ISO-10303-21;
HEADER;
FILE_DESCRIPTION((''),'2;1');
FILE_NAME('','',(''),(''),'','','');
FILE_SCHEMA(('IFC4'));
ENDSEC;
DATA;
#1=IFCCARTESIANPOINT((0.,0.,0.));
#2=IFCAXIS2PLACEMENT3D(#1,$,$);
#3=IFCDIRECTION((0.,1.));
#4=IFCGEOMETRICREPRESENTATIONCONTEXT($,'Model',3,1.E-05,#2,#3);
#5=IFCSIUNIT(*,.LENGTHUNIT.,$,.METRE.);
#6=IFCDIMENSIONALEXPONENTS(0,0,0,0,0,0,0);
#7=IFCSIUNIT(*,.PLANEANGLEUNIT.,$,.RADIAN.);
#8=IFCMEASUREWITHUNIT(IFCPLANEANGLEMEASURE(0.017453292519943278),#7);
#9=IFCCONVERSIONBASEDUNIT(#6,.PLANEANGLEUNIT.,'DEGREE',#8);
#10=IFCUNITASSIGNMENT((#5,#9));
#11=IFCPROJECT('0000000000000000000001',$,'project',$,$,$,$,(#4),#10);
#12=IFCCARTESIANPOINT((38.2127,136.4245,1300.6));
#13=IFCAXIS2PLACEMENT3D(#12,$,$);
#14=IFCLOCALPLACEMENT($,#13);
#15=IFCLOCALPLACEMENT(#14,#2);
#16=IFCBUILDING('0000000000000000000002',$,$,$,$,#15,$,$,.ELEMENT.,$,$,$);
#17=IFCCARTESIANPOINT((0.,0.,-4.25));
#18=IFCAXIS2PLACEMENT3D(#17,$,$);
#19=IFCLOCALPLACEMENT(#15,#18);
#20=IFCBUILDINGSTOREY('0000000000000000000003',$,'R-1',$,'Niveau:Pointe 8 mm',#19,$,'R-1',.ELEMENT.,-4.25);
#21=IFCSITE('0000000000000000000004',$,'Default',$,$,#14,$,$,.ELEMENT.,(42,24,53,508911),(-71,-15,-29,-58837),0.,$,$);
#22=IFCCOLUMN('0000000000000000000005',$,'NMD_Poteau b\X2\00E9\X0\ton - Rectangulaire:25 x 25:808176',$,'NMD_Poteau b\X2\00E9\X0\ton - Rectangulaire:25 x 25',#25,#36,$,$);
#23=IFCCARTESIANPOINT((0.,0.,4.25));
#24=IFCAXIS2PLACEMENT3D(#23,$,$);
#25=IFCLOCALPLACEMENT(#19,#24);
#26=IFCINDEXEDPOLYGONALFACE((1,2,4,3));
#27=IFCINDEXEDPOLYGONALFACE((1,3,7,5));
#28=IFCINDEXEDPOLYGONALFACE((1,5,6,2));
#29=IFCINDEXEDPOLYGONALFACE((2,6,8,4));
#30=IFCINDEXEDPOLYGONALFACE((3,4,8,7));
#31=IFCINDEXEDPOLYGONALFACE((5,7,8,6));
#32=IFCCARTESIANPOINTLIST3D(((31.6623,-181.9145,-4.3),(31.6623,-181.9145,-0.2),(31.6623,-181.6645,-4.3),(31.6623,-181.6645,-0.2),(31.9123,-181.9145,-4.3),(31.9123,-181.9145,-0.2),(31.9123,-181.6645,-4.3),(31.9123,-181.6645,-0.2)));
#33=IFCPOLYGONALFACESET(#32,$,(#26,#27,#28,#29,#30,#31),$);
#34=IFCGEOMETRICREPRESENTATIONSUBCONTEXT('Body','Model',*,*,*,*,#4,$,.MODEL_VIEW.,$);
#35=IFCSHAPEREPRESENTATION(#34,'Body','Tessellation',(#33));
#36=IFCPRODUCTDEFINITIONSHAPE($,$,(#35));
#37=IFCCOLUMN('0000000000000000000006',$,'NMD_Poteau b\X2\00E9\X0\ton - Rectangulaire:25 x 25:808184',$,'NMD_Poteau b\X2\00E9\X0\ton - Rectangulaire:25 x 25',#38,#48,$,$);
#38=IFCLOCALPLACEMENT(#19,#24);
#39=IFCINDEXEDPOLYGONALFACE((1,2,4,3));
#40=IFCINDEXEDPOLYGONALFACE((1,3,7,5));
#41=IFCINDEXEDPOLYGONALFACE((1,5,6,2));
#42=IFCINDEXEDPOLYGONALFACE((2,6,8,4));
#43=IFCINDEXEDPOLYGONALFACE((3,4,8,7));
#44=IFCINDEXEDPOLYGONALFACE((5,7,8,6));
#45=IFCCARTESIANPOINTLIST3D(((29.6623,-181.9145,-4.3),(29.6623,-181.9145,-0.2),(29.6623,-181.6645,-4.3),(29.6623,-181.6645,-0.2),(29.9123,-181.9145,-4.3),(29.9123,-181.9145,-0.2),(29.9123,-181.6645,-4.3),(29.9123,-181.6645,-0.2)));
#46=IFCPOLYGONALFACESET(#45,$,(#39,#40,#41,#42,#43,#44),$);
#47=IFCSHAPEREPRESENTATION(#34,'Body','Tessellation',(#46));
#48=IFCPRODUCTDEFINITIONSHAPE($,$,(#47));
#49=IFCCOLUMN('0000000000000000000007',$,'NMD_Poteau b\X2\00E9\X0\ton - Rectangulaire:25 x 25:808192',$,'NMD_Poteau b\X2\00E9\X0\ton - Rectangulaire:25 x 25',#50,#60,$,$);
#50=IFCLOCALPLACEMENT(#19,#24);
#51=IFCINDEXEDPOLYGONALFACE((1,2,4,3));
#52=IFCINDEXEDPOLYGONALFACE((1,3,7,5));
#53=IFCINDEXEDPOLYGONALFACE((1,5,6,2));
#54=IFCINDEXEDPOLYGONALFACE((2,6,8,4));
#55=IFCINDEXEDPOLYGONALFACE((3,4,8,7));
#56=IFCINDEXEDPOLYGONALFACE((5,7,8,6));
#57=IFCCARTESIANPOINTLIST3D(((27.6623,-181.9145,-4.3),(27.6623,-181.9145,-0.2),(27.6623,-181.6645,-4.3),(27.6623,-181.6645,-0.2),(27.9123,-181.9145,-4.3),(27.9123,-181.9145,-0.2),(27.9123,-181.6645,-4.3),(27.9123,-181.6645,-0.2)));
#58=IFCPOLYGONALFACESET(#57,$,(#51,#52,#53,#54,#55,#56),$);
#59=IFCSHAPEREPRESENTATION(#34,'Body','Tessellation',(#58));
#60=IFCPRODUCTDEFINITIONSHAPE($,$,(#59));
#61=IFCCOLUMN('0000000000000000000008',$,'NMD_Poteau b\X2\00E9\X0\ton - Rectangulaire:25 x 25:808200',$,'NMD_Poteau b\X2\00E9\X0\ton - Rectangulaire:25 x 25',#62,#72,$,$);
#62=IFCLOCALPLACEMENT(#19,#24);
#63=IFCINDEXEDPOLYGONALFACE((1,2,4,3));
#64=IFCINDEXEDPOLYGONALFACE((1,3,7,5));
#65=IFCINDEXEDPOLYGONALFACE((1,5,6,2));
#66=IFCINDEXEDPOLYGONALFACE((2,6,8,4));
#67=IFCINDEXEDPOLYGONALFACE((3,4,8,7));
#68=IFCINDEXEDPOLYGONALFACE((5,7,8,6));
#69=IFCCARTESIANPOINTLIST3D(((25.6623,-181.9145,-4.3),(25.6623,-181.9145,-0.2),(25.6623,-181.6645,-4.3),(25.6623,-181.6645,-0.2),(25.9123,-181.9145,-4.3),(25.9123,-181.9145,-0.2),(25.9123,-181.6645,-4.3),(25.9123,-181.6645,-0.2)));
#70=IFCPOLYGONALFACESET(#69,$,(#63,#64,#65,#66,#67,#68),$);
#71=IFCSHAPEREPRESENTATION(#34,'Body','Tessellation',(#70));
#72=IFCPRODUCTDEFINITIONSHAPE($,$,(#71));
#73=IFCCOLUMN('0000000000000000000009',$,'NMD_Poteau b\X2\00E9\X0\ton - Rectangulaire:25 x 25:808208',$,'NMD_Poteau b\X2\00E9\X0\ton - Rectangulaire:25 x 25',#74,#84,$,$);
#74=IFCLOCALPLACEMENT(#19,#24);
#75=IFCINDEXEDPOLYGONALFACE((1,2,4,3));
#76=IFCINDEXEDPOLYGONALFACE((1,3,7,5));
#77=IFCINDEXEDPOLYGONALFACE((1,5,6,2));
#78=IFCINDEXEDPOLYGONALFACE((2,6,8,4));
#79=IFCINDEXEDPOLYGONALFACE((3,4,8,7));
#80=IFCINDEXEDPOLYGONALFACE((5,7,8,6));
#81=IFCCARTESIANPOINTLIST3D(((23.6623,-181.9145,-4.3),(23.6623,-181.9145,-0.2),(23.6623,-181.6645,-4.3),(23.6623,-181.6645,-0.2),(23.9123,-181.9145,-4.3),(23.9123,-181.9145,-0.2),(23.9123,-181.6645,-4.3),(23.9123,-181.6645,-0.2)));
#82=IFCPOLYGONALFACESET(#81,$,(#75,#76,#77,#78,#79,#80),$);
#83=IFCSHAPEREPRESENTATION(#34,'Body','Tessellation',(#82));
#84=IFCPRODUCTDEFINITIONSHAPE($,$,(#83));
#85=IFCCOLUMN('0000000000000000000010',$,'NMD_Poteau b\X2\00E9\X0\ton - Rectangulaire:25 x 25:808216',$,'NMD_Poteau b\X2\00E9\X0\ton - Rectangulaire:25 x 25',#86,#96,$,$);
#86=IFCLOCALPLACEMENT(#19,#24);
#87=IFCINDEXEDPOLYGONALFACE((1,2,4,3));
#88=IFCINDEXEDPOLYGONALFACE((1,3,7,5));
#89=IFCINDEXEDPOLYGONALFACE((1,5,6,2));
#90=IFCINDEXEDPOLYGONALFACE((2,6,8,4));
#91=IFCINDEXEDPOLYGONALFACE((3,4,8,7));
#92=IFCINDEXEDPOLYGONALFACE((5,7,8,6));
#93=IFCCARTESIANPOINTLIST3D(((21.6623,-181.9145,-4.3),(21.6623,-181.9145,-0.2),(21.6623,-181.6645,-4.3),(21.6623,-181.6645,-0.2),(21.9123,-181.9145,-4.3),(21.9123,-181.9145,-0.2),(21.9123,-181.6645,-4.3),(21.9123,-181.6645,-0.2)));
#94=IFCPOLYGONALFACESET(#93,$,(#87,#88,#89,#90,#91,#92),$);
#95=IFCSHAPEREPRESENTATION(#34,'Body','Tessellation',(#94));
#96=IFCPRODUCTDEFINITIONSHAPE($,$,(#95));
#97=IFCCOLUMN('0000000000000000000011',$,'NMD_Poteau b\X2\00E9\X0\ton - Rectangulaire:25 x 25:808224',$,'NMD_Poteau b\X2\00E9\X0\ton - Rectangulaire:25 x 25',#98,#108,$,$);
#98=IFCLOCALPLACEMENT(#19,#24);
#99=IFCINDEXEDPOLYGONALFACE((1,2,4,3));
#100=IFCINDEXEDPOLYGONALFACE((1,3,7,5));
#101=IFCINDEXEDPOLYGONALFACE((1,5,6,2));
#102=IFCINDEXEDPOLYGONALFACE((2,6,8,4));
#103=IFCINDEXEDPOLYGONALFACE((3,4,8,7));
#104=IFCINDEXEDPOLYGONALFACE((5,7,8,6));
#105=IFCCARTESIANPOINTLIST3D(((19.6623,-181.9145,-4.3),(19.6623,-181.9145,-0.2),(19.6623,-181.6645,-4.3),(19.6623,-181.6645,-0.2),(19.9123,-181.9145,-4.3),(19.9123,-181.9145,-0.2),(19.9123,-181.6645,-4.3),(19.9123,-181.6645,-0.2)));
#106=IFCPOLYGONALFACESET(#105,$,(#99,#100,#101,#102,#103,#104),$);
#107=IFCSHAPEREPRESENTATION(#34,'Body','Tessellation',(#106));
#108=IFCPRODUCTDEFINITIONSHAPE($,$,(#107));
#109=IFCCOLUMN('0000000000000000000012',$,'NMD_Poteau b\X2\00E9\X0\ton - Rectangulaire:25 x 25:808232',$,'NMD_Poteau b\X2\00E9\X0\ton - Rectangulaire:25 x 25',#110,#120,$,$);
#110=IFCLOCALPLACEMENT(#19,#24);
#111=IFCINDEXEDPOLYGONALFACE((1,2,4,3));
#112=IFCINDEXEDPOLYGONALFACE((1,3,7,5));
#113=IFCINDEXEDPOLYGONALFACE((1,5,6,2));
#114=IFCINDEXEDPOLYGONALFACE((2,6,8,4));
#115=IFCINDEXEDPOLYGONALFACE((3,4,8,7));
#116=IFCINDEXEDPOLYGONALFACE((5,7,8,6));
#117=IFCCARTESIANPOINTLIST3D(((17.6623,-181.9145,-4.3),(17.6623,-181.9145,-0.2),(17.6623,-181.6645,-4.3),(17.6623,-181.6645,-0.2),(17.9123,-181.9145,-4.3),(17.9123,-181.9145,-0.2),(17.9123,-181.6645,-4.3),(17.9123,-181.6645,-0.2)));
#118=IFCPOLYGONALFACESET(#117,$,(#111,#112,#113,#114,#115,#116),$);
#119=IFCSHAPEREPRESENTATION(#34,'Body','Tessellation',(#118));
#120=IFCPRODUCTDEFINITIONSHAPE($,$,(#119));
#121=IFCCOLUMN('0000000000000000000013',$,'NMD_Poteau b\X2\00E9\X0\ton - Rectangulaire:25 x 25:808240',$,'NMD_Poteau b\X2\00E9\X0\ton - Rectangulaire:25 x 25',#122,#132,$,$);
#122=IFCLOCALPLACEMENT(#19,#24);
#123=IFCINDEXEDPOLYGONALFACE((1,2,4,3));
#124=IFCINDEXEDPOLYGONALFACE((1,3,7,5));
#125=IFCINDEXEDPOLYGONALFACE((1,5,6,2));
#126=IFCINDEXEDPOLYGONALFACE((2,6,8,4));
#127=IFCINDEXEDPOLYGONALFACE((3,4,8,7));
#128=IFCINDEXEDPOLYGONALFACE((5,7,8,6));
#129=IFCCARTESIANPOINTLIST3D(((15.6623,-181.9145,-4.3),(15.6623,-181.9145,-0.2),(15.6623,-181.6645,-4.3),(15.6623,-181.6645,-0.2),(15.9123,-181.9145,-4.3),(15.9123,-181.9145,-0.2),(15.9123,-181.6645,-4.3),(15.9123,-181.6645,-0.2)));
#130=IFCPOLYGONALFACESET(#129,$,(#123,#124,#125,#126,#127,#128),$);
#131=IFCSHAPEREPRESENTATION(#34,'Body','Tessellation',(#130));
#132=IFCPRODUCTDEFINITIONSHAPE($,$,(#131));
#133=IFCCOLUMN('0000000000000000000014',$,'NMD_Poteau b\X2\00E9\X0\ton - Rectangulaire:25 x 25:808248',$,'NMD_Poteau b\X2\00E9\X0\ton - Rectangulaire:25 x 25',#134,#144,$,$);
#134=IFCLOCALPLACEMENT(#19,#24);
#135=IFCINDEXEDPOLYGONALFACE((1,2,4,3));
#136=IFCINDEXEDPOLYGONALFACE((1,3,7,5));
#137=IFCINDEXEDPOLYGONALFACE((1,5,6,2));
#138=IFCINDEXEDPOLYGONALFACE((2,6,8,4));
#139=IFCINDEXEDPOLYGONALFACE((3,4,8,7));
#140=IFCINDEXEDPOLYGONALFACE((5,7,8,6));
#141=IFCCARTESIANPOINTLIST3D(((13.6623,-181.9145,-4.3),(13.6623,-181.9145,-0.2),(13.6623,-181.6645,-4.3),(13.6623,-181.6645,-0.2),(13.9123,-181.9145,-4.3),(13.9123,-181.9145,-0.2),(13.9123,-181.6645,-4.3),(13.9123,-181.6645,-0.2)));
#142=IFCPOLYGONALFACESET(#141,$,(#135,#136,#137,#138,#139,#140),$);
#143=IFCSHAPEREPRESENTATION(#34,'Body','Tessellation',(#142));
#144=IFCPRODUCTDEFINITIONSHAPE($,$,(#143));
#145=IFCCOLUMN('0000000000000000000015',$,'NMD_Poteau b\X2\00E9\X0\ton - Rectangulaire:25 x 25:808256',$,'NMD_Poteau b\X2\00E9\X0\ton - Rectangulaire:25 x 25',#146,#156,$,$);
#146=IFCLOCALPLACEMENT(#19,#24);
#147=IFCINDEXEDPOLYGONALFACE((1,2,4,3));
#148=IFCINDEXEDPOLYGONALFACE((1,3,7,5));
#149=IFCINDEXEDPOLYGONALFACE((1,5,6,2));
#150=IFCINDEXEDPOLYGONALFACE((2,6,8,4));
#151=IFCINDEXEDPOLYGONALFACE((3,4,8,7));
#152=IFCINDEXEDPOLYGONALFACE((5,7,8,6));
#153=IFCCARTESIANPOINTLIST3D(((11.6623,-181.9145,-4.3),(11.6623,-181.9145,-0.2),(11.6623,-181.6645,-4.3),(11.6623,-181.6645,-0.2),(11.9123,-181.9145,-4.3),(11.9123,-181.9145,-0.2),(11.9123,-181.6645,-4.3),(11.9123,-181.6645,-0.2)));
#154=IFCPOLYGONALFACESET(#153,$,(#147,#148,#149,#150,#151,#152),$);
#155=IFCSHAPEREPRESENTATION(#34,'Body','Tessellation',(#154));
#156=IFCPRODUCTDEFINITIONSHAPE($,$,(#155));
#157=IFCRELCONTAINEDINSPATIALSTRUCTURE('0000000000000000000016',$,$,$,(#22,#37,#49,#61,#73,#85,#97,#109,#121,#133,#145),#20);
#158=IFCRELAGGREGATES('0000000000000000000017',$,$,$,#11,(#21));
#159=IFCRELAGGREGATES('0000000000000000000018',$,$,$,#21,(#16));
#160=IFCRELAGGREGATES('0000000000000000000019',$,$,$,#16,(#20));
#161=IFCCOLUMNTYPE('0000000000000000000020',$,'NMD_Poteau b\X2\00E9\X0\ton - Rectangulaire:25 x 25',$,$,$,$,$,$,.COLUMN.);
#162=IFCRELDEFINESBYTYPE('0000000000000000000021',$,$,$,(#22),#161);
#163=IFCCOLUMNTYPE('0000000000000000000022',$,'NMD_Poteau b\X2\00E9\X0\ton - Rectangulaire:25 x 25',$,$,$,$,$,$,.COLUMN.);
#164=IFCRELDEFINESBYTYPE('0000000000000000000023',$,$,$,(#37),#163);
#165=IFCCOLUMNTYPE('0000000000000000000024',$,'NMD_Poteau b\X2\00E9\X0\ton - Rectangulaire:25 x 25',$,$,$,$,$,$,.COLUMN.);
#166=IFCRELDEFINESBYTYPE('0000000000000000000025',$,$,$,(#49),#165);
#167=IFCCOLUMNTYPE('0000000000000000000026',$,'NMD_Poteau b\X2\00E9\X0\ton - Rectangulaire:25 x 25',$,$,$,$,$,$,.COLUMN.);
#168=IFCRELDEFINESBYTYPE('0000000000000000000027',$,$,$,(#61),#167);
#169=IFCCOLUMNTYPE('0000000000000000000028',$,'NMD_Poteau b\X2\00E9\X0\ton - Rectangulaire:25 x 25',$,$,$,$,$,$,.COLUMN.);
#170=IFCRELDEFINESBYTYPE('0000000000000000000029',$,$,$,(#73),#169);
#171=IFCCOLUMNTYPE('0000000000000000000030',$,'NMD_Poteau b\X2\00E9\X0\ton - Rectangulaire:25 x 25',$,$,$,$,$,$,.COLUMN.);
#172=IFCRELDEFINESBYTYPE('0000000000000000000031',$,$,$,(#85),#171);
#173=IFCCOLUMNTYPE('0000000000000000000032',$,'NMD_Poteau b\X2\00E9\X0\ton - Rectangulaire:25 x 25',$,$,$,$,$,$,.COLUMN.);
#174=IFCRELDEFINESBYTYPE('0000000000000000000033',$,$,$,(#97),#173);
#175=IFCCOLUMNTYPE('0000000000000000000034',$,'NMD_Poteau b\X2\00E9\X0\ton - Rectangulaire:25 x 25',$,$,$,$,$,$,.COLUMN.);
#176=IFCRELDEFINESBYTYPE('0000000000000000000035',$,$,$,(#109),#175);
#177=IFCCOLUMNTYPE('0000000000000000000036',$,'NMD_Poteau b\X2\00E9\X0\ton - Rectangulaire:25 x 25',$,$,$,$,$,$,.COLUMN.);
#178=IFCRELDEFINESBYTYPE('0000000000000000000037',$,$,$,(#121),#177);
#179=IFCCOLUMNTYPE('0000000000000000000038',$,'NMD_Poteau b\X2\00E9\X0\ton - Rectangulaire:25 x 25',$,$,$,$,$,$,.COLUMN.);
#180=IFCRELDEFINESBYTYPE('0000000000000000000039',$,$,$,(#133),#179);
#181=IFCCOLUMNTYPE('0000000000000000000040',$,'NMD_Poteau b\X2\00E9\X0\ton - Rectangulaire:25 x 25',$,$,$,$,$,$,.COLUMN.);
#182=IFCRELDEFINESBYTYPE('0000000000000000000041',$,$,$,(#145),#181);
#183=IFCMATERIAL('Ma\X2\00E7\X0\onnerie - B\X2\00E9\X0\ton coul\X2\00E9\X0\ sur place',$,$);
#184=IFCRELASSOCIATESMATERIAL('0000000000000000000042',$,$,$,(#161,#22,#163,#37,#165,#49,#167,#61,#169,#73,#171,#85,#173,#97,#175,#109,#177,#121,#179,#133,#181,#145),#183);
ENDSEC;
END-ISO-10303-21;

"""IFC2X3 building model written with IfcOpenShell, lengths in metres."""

from ifc_helpers import new_model, entity, si_unit, converted_unit, direction, frame, frame_2d, origin, place, context, subcontext, project, spatial, rectangle, extrude, source, transform, mapped, material, type_object, type_shapes, element, save


model = new_model("IFC2X3")

# Units and contexts
model_context = context("Model", 3, precision=1e-05, world=origin(), true_north=direction((0.0, 1.0)))
body_context = subcontext(model_context, "Body", "Model", "MODEL_VIEW")
ifc_project = project(units=[si_unit("LENGTHUNIT", "METRE"), converted_unit("PLANEANGLEUNIT", "DEGREE", entity("IfcPlaneAngleMeasure", 0.017453292519943278), si_unit("PLANEANGLEUNIT", "RADIAN"), dimensions=[0, 0, 0, 0, 0, 0, 0])], contexts=[model_context])

# Site, building, storey
site_placement = place(None, frame((38.2127, 136.4245, 1300.6)))
site = spatial("IfcSite", under=ifc_project, at=site_placement, Name="Default", CompositionType="ELEMENT", RefLatitude=(42, 24, 53, 508911), RefLongitude=(-71, -15, -29, -58837), RefElevation=0.0)
building_placement = place(site_placement, origin())
building = spatial("IfcBuilding", under=site, at=building_placement, CompositionType="ELEMENT")
storey_placement = place(building_placement, frame((0.0, 0.0, -4.25)))
storey = spatial("IfcBuildingStorey", under=building, at=storey_placement, Name="R-1", ObjectType="Niveau:Pointe 8 mm", LongName="R-1", CompositionType="ELEMENT", Elevation=-4.25)

# Columns
ifc_material = material(Name="Maçonnerie - Béton coulé sur place")
column_type_1 = type_object("IfcColumnType", Name="NMD_Poteau béton - Rectangulaire:25 x 25", PredefinedType="COLUMN", material=ifc_material)
shared_shape_1 = source(origin(), body_context, "Body", "SweptSolid", [
    extrude(rectangle(XDim=0.25, YDim=0.25, at=frame_2d((0.0, 0.0), x_axis=(1.0, 0.0))), frame((31.7873, -181.7895, -4.3), z_axis=(0.0, 0.0, 1.0), x_axis=(-1.0, 0.0, 0.0)), (0.0, 0.0, 1.0), 4.1),
])
type_shapes(column_type_1, [shared_shape_1])
column_1_placement = place(storey_placement, frame((0.0, 0.0, 4.25)))
element("IfcColumn", 1, at=column_1_placement, inside=storey, type_object=column_type_1, material=ifc_material, Name="NMD_Poteau béton - Rectangulaire:25 x 25:808176", ObjectType="NMD_Poteau béton - Rectangulaire:25 x 25", context=body_context, shape_type="MappedRepresentation", body=[
    mapped(shared_shape_1, transform((0.0, 0.0, 0.0), scale=1.0)),
])
column_type_2 = type_object("IfcColumnType", Name="NMD_Poteau béton - Rectangulaire:25 x 25", PredefinedType="COLUMN", material=ifc_material)
shared_shape_2 = source(origin(), body_context, "Body", "SweptSolid", [
    extrude(rectangle(XDim=0.25, YDim=0.25, at=frame_2d((0.0, 0.0), x_axis=(1.0, 0.0))), frame((29.7873, -181.7895, -4.3), z_axis=(0.0, 0.0, 1.0), x_axis=(-1.0, 0.0, 0.0)), (0.0, 0.0, 1.0), 4.1),
])
type_shapes(column_type_2, [shared_shape_2])
column_2_placement = place(storey_placement, frame((0.0, 0.0, 4.25)))
element("IfcColumn", 2, at=column_2_placement, inside=storey, type_object=column_type_2, material=ifc_material, Name="NMD_Poteau béton - Rectangulaire:25 x 25:808184", ObjectType="NMD_Poteau béton - Rectangulaire:25 x 25", context=body_context, shape_type="MappedRepresentation", body=[
    mapped(shared_shape_2, transform((0.0, 0.0, 0.0), scale=1.0)),
])
column_type_3 = type_object("IfcColumnType", Name="NMD_Poteau béton - Rectangulaire:25 x 25", PredefinedType="COLUMN", material=ifc_material)
shared_shape_3 = source(origin(), body_context, "Body", "SweptSolid", [
    extrude(rectangle(XDim=0.25, YDim=0.25, at=frame_2d((0.0, 0.0), x_axis=(1.0, 0.0))), frame((27.7873, -181.7895, -4.3), z_axis=(0.0, 0.0, 1.0), x_axis=(-1.0, 0.0, 0.0)), (0.0, 0.0, 1.0), 4.1),
])
type_shapes(column_type_3, [shared_shape_3])
column_3_placement = place(storey_placement, frame((0.0, 0.0, 4.25)))
element("IfcColumn", 3, at=column_3_placement, inside=storey, type_object=column_type_3, material=ifc_material, Name="NMD_Poteau béton - Rectangulaire:25 x 25:808192", ObjectType="NMD_Poteau béton - Rectangulaire:25 x 25", context=body_context, shape_type="MappedRepresentation", body=[
    mapped(shared_shape_3, transform((0.0, 0.0, 0.0), scale=1.0)),
])
column_type_4 = type_object("IfcColumnType", Name="NMD_Poteau béton - Rectangulaire:25 x 25", PredefinedType="COLUMN", material=ifc_material)
shared_shape_4 = source(origin(), body_context, "Body", "SweptSolid", [
    extrude(rectangle(XDim=0.25, YDim=0.25, at=frame_2d((0.0, 0.0), x_axis=(1.0, 0.0))), frame((25.7873, -181.7895, -4.3), z_axis=(0.0, 0.0, 1.0), x_axis=(-1.0, 0.0, 0.0)), (0.0, 0.0, 1.0), 4.1),
])
type_shapes(column_type_4, [shared_shape_4])
column_4_placement = place(storey_placement, frame((0.0, 0.0, 4.25)))
element("IfcColumn", 4, at=column_4_placement, inside=storey, type_object=column_type_4, material=ifc_material, Name="NMD_Poteau béton - Rectangulaire:25 x 25:808200", ObjectType="NMD_Poteau béton - Rectangulaire:25 x 25", context=body_context, shape_type="MappedRepresentation", body=[
    mapped(shared_shape_4, transform((0.0, 0.0, 0.0), scale=1.0)),
])
column_type_5 = type_object("IfcColumnType", Name="NMD_Poteau béton - Rectangulaire:25 x 25", PredefinedType="COLUMN", material=ifc_material)
shared_shape_5 = source(origin(), body_context, "Body", "SweptSolid", [
    extrude(rectangle(XDim=0.25, YDim=0.25, at=frame_2d((0.0, 0.0), x_axis=(1.0, 0.0))), frame((23.7873, -181.7895, -4.3), z_axis=(0.0, 0.0, 1.0), x_axis=(-1.0, 0.0, 0.0)), (0.0, 0.0, 1.0), 4.1),
])
type_shapes(column_type_5, [shared_shape_5])
column_5_placement = place(storey_placement, frame((0.0, 0.0, 4.25)))
element("IfcColumn", 5, at=column_5_placement, inside=storey, type_object=column_type_5, material=ifc_material, Name="NMD_Poteau béton - Rectangulaire:25 x 25:808208", ObjectType="NMD_Poteau béton - Rectangulaire:25 x 25", context=body_context, shape_type="MappedRepresentation", body=[
    mapped(shared_shape_5, transform((0.0, 0.0, 0.0), scale=1.0)),
])
column_type_6 = type_object("IfcColumnType", Name="NMD_Poteau béton - Rectangulaire:25 x 25", PredefinedType="COLUMN", material=ifc_material)
shared_shape_6 = source(origin(), body_context, "Body", "SweptSolid", [
    extrude(rectangle(XDim=0.25, YDim=0.25, at=frame_2d((0.0, 0.0), x_axis=(1.0, 0.0))), frame((21.7873, -181.7895, -4.3), z_axis=(0.0, 0.0, 1.0), x_axis=(-1.0, 0.0, 0.0)), (0.0, 0.0, 1.0), 4.1),
])
type_shapes(column_type_6, [shared_shape_6])
column_6_placement = place(storey_placement, frame((0.0, 0.0, 4.25)))
element("IfcColumn", 6, at=column_6_placement, inside=storey, type_object=column_type_6, material=ifc_material, Name="NMD_Poteau béton - Rectangulaire:25 x 25:808216", ObjectType="NMD_Poteau béton - Rectangulaire:25 x 25", context=body_context, shape_type="MappedRepresentation", body=[
    mapped(shared_shape_6, transform((0.0, 0.0, 0.0), scale=1.0)),
])
column_type_7 = type_object("IfcColumnType", Name="NMD_Poteau béton - Rectangulaire:25 x 25", PredefinedType="COLUMN", material=ifc_material)
shared_shape_7 = source(origin(), body_context, "Body", "SweptSolid", [
    extrude(rectangle(XDim=0.25, YDim=0.25, at=frame_2d((0.0, 0.0), x_axis=(1.0, 0.0))), frame((19.7873, -181.7895, -4.3), z_axis=(0.0, 0.0, 1.0), x_axis=(-1.0, 0.0, 0.0)), (0.0, 0.0, 1.0), 4.1),
])
type_shapes(column_type_7, [shared_shape_7])
column_7_placement = place(storey_placement, frame((0.0, 0.0, 4.25)))
element("IfcColumn", 7, at=column_7_placement, inside=storey, type_object=column_type_7, material=ifc_material, Name="NMD_Poteau béton - Rectangulaire:25 x 25:808224", ObjectType="NMD_Poteau béton - Rectangulaire:25 x 25", context=body_context, shape_type="MappedRepresentation", body=[
    mapped(shared_shape_7, transform((0.0, 0.0, 0.0), scale=1.0)),
])
column_type_8 = type_object("IfcColumnType", Name="NMD_Poteau béton - Rectangulaire:25 x 25", PredefinedType="COLUMN", material=ifc_material)
shared_shape_8 = source(origin(), body_context, "Body", "SweptSolid", [
    extrude(rectangle(XDim=0.25, YDim=0.25, at=frame_2d((0.0, 0.0), x_axis=(1.0, 0.0))), frame((17.7873, -181.7895, -4.3), z_axis=(0.0, 0.0, 1.0), x_axis=(-1.0, 0.0, 0.0)), (0.0, 0.0, 1.0), 4.1),
])
type_shapes(column_type_8, [shared_shape_8])
column_8_placement = place(storey_placement, frame((0.0, 0.0, 4.25)))
element("IfcColumn", 8, at=column_8_placement, inside=storey, type_object=column_type_8, material=ifc_material, Name="NMD_Poteau béton - Rectangulaire:25 x 25:808232", ObjectType="NMD_Poteau béton - Rectangulaire:25 x 25", context=body_context, shape_type="MappedRepresentation", body=[
    mapped(shared_shape_8, transform((0.0, 0.0, 0.0), scale=1.0)),
])
column_type_9 = type_object("IfcColumnType", Name="NMD_Poteau béton - Rectangulaire:25 x 25", PredefinedType="COLUMN", material=ifc_material)
shared_shape_9 = source(origin(), body_context, "Body", "SweptSolid", [
    extrude(rectangle(XDim=0.25, YDim=0.25, at=frame_2d((0.0, 0.0), x_axis=(1.0, 0.0))), frame((15.7873, -181.7895, -4.3), z_axis=(0.0, 0.0, 1.0), x_axis=(-1.0, 0.0, 0.0)), (0.0, 0.0, 1.0), 4.1),
])
type_shapes(column_type_9, [shared_shape_9])
column_9_placement = place(storey_placement, frame((0.0, 0.0, 4.25)))
element("IfcColumn", 9, at=column_9_placement, inside=storey, type_object=column_type_9, material=ifc_material, Name="NMD_Poteau béton - Rectangulaire:25 x 25:808240", ObjectType="NMD_Poteau béton - Rectangulaire:25 x 25", context=body_context, shape_type="MappedRepresentation", body=[
    mapped(shared_shape_9, transform((0.0, 0.0, 0.0), scale=1.0)),
])
column_type_10 = type_object("IfcColumnType", Name="NMD_Poteau béton - Rectangulaire:25 x 25", PredefinedType="COLUMN", material=ifc_material)
shared_shape_10 = source(origin(), body_context, "Body", "SweptSolid", [
    extrude(rectangle(XDim=0.25, YDim=0.25, at=frame_2d((0.0, 0.0), x_axis=(1.0, 0.0))), frame((13.7873, -181.7895, -4.3), z_axis=(0.0, 0.0, 1.0), x_axis=(-1.0, 0.0, 0.0)), (0.0, 0.0, 1.0), 4.1),
])
type_shapes(column_type_10, [shared_shape_10])
column_10_placement = place(storey_placement, frame((0.0, 0.0, 4.25)))
element("IfcColumn", 10, at=column_10_placement, inside=storey, type_object=column_type_10, material=ifc_material, Name="NMD_Poteau béton - Rectangulaire:25 x 25:808248", ObjectType="NMD_Poteau béton - Rectangulaire:25 x 25", context=body_context, shape_type="MappedRepresentation", body=[
    mapped(shared_shape_10, transform((0.0, 0.0, 0.0), scale=1.0)),
])
column_type_11 = type_object("IfcColumnType", Name="NMD_Poteau béton - Rectangulaire:25 x 25", PredefinedType="COLUMN", material=ifc_material)
shared_shape_11 = source(origin(), body_context, "Body", "SweptSolid", [
    extrude(rectangle(XDim=0.25, YDim=0.25, at=frame_2d((0.0, 0.0), x_axis=(1.0, 0.0))), frame((11.7873, -181.7895, -4.3), z_axis=(0.0, 0.0, 1.0), x_axis=(-1.0, 0.0, 0.0)), (0.0, 0.0, 1.0), 4.1),
])
type_shapes(column_type_11, [shared_shape_11])
column_11_placement = place(storey_placement, frame((0.0, 0.0, 4.25)))
element("IfcColumn", 11, at=column_11_placement, inside=storey, type_object=column_type_11, material=ifc_material, Name="NMD_Poteau béton - Rectangulaire:25 x 25:808256", ObjectType="NMD_Poteau béton - Rectangulaire:25 x 25", context=body_context, shape_type="MappedRepresentation", body=[
    mapped(shared_shape_11, transform((0.0, 0.0, 0.0), scale=1.0)),
])

save(model, "model.ifc")
